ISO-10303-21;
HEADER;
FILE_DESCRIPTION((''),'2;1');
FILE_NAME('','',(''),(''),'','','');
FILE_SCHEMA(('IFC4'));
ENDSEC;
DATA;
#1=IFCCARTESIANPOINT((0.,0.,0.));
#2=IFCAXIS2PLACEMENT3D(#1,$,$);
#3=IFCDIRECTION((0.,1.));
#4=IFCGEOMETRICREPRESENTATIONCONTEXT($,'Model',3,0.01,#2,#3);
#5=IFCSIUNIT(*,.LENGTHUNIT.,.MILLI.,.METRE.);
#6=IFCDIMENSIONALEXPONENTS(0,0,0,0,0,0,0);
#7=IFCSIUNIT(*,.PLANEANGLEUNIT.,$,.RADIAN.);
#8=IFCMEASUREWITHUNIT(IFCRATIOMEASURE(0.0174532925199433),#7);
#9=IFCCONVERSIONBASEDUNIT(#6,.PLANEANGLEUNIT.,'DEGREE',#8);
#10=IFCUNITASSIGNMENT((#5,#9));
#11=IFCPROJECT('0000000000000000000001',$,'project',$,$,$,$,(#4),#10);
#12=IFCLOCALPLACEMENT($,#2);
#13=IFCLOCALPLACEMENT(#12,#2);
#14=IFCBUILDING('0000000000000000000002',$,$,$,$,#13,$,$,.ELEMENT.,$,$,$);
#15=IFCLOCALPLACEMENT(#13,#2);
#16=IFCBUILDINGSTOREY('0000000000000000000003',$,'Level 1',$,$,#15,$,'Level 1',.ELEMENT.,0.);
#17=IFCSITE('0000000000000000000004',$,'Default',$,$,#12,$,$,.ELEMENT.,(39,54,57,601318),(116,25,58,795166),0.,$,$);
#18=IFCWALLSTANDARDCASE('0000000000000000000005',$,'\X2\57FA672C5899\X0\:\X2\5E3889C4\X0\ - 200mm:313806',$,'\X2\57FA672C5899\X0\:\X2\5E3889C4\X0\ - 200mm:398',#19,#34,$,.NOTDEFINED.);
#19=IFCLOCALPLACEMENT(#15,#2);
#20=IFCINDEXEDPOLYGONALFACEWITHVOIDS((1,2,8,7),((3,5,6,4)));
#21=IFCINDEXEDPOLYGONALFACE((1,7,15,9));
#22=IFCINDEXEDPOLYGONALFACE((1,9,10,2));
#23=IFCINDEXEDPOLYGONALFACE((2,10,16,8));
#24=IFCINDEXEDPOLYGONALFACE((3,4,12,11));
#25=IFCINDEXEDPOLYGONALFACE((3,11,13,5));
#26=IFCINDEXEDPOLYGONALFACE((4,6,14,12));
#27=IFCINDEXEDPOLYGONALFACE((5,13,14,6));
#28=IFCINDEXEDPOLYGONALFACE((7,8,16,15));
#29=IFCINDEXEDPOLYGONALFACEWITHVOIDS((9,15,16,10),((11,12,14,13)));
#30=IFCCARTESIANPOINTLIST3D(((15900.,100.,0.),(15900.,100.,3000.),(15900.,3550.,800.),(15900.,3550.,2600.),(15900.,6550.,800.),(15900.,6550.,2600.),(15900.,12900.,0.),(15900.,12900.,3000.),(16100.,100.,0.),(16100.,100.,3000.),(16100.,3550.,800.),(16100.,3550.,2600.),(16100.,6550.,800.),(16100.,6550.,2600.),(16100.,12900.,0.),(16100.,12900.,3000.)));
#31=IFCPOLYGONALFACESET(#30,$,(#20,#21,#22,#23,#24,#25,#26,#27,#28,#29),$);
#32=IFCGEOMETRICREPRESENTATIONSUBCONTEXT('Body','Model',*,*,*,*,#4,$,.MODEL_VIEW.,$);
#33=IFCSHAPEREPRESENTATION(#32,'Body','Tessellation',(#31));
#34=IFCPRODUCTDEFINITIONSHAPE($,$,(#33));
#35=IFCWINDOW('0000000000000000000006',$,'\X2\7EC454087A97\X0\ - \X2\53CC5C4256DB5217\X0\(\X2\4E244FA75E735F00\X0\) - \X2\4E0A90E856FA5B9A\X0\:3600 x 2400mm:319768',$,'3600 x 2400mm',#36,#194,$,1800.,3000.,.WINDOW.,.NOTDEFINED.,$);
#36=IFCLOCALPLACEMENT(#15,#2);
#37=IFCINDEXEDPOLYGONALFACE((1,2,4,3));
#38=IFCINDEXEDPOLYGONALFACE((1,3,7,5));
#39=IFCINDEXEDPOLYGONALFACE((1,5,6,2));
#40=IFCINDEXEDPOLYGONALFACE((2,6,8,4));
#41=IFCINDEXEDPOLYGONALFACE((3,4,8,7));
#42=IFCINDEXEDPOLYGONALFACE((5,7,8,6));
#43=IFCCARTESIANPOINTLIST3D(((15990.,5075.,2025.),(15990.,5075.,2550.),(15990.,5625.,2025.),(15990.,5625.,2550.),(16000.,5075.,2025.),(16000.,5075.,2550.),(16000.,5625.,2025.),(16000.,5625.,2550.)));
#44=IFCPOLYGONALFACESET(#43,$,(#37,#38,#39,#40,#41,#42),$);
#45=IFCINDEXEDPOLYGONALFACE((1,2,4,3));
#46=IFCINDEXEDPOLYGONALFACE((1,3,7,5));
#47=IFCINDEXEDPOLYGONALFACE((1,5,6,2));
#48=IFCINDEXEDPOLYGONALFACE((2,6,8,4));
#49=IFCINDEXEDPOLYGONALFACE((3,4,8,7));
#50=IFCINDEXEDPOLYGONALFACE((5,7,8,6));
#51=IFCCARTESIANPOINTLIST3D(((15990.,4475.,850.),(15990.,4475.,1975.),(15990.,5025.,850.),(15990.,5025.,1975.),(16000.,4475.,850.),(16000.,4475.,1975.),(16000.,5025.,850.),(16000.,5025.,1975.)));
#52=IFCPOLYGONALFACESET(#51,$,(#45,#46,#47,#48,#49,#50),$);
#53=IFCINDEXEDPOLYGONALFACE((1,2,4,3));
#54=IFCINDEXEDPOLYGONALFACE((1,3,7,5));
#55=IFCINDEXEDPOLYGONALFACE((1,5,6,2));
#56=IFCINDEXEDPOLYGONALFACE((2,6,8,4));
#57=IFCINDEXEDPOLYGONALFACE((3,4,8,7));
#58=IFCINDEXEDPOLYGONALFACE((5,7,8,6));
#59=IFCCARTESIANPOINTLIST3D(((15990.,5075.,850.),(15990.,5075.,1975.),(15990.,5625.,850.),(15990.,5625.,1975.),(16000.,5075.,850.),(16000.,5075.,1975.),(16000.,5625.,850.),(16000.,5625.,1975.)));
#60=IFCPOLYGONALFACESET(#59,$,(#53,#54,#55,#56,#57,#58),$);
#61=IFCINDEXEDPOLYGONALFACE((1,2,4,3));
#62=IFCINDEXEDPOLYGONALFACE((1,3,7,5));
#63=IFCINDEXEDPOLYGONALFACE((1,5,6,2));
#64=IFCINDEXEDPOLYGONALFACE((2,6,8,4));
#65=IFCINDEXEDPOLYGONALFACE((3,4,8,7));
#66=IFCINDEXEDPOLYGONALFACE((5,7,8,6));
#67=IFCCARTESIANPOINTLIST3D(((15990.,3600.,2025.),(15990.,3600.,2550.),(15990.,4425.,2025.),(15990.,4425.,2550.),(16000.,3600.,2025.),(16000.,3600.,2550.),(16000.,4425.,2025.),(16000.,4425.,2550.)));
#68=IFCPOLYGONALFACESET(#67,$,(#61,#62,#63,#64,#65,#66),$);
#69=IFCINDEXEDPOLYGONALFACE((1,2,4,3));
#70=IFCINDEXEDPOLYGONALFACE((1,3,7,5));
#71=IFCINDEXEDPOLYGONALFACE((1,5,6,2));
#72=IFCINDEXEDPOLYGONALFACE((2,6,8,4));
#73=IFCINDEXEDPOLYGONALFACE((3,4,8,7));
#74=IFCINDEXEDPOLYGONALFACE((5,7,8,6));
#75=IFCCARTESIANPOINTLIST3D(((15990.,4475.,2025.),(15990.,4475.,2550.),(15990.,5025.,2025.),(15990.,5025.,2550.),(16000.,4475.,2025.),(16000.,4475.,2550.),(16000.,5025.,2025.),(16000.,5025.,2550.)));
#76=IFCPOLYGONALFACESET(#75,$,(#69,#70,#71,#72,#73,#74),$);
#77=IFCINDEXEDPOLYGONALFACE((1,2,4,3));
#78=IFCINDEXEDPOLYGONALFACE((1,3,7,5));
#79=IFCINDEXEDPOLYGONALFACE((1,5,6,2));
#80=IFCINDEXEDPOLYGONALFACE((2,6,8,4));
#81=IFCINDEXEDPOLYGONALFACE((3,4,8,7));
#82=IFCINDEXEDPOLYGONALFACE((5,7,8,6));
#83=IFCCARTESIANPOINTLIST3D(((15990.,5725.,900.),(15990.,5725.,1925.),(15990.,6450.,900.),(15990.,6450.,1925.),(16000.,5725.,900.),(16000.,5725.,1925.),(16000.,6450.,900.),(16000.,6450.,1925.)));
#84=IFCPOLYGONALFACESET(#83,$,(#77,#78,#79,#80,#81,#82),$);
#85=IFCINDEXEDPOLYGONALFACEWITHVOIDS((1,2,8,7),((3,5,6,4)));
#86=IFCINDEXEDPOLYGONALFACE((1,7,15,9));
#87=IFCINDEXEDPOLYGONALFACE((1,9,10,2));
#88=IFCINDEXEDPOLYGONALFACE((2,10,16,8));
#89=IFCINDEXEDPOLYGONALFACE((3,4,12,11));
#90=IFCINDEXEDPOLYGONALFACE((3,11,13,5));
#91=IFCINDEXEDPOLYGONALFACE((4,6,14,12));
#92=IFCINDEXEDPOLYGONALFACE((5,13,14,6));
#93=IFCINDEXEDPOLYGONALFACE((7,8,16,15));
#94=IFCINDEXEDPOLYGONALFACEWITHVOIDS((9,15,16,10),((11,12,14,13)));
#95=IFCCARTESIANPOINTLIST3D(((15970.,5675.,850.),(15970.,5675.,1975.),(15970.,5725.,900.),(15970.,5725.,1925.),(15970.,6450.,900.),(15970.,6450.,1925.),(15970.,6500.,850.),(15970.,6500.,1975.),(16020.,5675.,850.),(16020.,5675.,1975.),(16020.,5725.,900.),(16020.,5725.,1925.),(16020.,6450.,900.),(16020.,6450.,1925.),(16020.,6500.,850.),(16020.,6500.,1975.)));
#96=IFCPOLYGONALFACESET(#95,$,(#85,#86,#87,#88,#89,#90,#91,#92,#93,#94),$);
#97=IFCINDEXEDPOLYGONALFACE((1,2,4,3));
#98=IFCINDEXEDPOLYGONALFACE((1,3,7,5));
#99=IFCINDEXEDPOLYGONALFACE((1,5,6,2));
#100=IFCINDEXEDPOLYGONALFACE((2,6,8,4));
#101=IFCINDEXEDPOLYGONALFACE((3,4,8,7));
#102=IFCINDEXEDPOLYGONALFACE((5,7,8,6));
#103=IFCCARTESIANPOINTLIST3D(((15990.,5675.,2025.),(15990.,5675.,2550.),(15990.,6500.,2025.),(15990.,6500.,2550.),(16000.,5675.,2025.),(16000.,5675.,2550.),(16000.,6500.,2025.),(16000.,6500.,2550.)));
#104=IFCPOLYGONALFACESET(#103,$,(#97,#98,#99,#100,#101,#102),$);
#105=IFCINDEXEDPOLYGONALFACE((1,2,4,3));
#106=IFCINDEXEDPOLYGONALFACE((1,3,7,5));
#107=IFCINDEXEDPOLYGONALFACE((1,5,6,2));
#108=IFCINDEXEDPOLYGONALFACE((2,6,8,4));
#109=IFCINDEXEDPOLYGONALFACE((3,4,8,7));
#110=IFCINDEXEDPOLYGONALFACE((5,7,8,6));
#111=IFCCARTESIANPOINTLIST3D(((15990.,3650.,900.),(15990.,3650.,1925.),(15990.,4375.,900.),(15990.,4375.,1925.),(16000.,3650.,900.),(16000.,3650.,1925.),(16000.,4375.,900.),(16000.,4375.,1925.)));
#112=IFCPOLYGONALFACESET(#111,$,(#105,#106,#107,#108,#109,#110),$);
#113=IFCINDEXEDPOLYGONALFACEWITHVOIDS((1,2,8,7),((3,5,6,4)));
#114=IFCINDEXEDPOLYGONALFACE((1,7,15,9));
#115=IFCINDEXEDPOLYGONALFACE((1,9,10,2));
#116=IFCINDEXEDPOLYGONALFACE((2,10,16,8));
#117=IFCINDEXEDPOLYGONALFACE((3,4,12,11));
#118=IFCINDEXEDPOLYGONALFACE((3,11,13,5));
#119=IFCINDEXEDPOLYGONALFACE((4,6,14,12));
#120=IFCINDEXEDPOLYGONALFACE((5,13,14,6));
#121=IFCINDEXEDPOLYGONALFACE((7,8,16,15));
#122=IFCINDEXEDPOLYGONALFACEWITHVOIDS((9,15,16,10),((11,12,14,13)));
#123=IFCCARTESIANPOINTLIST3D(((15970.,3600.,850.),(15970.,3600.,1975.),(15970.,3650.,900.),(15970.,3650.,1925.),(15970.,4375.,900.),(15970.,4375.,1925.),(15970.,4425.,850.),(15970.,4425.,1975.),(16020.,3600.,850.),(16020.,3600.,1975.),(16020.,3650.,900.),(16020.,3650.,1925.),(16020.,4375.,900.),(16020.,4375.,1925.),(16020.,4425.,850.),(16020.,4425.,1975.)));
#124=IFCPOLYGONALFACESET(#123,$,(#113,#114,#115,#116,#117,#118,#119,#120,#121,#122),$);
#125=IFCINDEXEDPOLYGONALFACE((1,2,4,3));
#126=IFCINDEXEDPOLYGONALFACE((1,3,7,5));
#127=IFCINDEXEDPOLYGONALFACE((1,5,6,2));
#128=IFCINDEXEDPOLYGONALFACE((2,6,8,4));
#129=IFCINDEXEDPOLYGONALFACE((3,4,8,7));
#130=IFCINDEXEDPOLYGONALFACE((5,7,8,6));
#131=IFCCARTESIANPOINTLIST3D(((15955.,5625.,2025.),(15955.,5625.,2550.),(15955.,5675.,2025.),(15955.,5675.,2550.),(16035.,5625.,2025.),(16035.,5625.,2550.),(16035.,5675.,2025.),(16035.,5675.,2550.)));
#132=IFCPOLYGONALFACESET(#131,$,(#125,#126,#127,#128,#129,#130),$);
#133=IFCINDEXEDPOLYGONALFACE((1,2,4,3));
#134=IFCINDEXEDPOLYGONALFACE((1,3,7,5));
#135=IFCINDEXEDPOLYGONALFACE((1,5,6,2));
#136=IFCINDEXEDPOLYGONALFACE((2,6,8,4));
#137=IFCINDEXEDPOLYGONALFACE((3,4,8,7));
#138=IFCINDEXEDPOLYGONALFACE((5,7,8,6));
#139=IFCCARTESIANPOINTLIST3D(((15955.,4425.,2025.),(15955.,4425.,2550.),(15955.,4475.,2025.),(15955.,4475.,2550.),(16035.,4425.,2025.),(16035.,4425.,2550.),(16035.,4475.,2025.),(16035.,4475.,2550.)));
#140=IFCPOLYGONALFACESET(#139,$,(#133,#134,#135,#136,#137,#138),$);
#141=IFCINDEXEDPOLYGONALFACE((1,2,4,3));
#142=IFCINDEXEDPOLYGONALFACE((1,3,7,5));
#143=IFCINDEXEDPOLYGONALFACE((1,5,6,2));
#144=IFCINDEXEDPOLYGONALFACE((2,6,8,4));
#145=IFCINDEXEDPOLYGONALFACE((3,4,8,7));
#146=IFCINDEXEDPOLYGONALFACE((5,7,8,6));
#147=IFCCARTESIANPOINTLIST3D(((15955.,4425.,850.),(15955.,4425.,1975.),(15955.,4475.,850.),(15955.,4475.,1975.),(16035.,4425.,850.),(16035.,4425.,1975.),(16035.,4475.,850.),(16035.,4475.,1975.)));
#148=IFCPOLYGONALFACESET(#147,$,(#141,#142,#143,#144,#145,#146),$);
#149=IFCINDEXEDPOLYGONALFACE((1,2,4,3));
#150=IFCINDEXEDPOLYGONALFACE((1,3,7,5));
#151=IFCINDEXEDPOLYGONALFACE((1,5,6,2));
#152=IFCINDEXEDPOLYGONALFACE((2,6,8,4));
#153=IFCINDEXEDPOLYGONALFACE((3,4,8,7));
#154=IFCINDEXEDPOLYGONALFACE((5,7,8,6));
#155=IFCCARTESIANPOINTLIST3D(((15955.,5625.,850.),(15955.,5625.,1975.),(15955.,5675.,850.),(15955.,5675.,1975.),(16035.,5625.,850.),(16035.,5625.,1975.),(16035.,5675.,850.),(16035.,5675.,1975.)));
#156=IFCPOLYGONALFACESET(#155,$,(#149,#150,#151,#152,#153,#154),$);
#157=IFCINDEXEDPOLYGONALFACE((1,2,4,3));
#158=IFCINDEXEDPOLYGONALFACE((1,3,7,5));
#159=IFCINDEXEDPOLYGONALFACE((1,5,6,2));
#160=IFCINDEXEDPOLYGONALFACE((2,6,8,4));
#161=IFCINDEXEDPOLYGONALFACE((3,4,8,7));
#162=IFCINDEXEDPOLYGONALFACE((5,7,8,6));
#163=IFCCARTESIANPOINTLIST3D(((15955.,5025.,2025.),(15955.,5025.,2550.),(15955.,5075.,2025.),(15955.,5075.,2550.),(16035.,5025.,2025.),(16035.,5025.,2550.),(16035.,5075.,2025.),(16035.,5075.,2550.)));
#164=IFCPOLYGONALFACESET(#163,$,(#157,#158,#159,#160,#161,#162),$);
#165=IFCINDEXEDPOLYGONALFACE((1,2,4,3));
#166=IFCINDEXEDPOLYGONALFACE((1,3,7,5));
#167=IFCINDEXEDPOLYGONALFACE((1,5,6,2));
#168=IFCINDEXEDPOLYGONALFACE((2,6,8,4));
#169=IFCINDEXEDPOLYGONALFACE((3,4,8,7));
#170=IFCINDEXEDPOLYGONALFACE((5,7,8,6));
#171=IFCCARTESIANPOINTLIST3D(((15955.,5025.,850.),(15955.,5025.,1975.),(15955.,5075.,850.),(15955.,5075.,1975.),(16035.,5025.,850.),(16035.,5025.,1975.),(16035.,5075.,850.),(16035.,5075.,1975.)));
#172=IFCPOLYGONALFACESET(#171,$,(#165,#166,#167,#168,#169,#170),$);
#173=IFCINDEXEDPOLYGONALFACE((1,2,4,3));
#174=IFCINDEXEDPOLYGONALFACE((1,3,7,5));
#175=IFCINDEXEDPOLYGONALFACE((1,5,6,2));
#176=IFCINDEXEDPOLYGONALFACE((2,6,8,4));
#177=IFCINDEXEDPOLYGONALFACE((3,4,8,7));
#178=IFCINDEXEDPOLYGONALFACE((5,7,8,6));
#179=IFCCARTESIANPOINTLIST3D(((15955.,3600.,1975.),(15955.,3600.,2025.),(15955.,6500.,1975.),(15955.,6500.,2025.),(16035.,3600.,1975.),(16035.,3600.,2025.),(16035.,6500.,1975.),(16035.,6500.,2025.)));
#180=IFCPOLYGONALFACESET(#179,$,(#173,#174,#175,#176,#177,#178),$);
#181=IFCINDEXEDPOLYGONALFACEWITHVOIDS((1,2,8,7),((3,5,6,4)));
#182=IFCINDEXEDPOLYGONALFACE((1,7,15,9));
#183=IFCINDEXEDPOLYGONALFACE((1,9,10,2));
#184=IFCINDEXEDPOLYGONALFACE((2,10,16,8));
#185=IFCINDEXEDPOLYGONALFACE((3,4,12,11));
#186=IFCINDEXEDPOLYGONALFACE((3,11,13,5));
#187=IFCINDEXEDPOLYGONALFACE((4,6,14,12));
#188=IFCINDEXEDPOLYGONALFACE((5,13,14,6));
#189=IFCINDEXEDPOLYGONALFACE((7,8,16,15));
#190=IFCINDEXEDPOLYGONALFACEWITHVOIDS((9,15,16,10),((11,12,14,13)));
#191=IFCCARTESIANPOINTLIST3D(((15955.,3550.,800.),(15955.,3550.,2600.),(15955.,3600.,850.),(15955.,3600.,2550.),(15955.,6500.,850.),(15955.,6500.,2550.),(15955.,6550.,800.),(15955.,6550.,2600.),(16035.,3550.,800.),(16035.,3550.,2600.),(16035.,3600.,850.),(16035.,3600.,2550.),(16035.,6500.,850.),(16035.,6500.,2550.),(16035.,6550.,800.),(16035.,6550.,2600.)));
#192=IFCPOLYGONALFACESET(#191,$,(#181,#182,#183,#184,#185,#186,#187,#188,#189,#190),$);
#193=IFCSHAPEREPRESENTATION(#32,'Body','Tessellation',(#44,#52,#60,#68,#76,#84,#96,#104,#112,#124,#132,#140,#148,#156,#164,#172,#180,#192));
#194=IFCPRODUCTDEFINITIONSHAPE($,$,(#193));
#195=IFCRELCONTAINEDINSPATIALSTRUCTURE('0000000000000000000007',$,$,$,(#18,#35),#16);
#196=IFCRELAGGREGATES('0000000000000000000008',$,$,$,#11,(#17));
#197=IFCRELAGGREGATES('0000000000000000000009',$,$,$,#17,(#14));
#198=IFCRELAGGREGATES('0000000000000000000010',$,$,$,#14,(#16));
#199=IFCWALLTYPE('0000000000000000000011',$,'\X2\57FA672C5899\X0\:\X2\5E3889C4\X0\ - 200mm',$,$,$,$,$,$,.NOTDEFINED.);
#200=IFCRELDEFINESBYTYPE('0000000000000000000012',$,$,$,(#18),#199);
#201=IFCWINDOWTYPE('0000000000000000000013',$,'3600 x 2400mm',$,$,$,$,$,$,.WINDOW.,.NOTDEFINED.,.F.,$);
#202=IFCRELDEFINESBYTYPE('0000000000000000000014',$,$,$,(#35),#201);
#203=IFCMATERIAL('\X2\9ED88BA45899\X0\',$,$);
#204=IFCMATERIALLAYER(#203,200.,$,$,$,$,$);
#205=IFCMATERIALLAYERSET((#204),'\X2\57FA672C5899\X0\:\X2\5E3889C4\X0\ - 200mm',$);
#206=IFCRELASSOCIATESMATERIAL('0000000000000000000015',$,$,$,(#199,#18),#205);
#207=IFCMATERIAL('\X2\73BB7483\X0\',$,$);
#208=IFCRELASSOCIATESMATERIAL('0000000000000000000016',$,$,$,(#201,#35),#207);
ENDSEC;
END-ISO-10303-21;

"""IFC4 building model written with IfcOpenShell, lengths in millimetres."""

from ifc_helpers import new_model, entity, si_unit, converted_unit, direction, frame, frame_2d, origin, origin_2d_with_axis, place, context, subcontext, project, spatial, polyline, rectangle, outline, extrude, source, transform, mapped, material, layer, layer_set, layer_usage, type_object, type_shapes, element, fill, save


model = new_model("IFC4")

# Units and contexts
model_context = context("Model", 3, precision=0.01, world=origin(), true_north=direction((0.0, 1.0)))
body_context = subcontext(model_context, "Body", "Model", "MODEL_VIEW")
ifc_project = project(units=[si_unit("LENGTHUNIT", "METRE", prefix="MILLI"), converted_unit("PLANEANGLEUNIT", "DEGREE", entity("IfcRatioMeasure", 0.0174532925199433), si_unit("PLANEANGLEUNIT", "RADIAN"), dimensions=[0, 0, 0, 0, 0, 0, 0])], contexts=[model_context])

# Site, building, storey
site_placement = place(None, origin())
site = spatial("IfcSite", under=ifc_project, at=site_placement, Name="Default", CompositionType="ELEMENT", RefLatitude=(39, 54, 57, 601318), RefLongitude=(116, 25, 58, 795166), RefElevation=0.0)
building_placement = place(site_placement, origin())
building = spatial("IfcBuilding", under=site, at=building_placement, CompositionType="ELEMENT")
storey_placement = place(building_placement, origin())
storey = spatial("IfcBuildingStorey", under=building, at=storey_placement, Name="Level 1", LongName="Level 1", CompositionType="ELEMENT", Elevation=0.0)

# Shared definitions
ifc_material_1 = material(Name="默认墙")
ifc_layer = layer(ifc_material_1, 200.0)
ifc_layer_set = layer_set([ifc_layer], Name="基本墙:常规 - 200mm")
wall_type = type_object("IfcWallType", Name="基本墙:常规 - 200mm", PredefinedType="NOTDEFINED", material=ifc_layer_set)
ifc_material_2 = material(Name="玻璃")
window_type_1 = type_object("IfcWindowType", Name="3600 x 2400mm", ParameterTakesPrecedence=False, PartitioningType="NOTDEFINED", PredefinedType="WINDOW", material=ifc_material_2)
shared_shape_1 = source(origin(), body_context, "Body", "SweptSolid", [
    extrude(rectangle(XDim=10.0, YDim=550.0, at=origin_2d_with_axis()), frame((1200.0, 95.0, 1225.0), z_axis=(0.0, 0.0, 1.0), x_axis=(0.0, 1.0, 0.0)), (0.0, 0.0, 1.0), 525.0),
    extrude(rectangle(XDim=10.0, YDim=550.0, at=origin_2d_with_axis()), frame((1800.0, 95.0, 50.0), z_axis=(0.0, 0.0, 1.0), x_axis=(0.0, 1.0, 0.0)), (0.0, 0.0, 1.0), 1125.0),
    extrude(rectangle(XDim=10.0, YDim=550.0, at=origin_2d_with_axis()), frame((1200.0, 95.0, 50.0), z_axis=(0.0, 0.0, 1.0), x_axis=(0.0, 1.0, 0.0)), (0.0, 0.0, 1.0), 1125.0),
    extrude(rectangle(XDim=10.0, YDim=825.0, at=frame_2d((0.0, 0.0), x_axis=(1.0, 0.0))), frame((2537.5, 95.0, 1225.0), z_axis=(0.0, 0.0, 1.0), x_axis=(0.0, 1.0, 0.0)), (0.0, 0.0, 1.0), 525.0),
    extrude(rectangle(XDim=10.0, YDim=550.0, at=frame_2d((0.0, 0.0), x_axis=(1.0, 0.0))), frame((1800.0, 95.0, 1225.0), z_axis=(0.0, 0.0, 1.0), x_axis=(0.0, 1.0, 0.0)), (0.0, 0.0, 1.0), 525.0),
    extrude(rectangle(XDim=10.0, YDim=725.0, at=frame_2d((0.0, 0.0), x_axis=(1.0, 0.0))), frame((462.5, 95.0, 100.0), z_axis=(0.0, 0.0, 1.0), x_axis=(0.0, 1.0, 0.0)), (0.0, 0.0, 1.0), 1025.0),
    extrude(outline(polyline([(-562.5, -412.5), (562.5, -412.5), (562.5, 412.5), (-562.5, 412.5), (-562.5, -412.5)]), holes=[polyline([(512.5, -362.5), (-512.5, -362.5), (-512.5, 362.5), (512.5, 362.5), (512.5, -362.5)])]), frame((462.5, 70.0, 612.5), z_axis=(0.0, 1.0, 0.0), x_axis=(0.0, 0.0, -1.0)), (0.0, 0.0, 1.0), 50.0),
    extrude(rectangle(XDim=10.0, YDim=825.0, at=origin_2d_with_axis()), frame((462.5, 95.0, 1225.0), z_axis=(0.0, 0.0, 1.0), x_axis=(0.0, 1.0, 0.0)), (0.0, 0.0, 1.0), 525.0),
    extrude(rectangle(XDim=10.0, YDim=725.0, at=frame_2d((0.0, 0.0), x_axis=(1.0, 0.0))), frame((2537.5, 95.0, 100.0), z_axis=(0.0, 0.0, 1.0), x_axis=(0.0, 1.0, 0.0)), (0.0, 0.0, 1.0), 1025.0),
    extrude(outline(polyline([(-562.5, -412.5), (562.5, -412.5), (562.5, 412.5), (-562.5, 412.5), (-562.5, -412.5)]), holes=[polyline([(512.5, -362.5), (-512.5, -362.5), (-512.5, 362.5), (512.5, 362.5), (512.5, -362.5)])]), frame((2537.5, 70.0, 612.5), z_axis=(0.0, 1.0, 0.0), x_axis=(0.0, 0.0, -1.0)), (0.0, 0.0, 1.0), 50.0),
    extrude(rectangle(XDim=80.0, YDim=50.0, at=origin_2d_with_axis()), frame((900.0, 95.0, 1225.0), z_axis=(0.0, 0.0, 1.0), x_axis=(0.0, -1.0, 0.0)), (0.0, 0.0, 1.0), 525.0),
    extrude(rectangle(XDim=80.0, YDim=50.0, at=frame_2d((0.0, 0.0), x_axis=(1.0, 0.0))), frame((2100.0, 95.0, 1225.0), z_axis=(0.0, 0.0, 1.0), x_axis=(0.0, -1.0, 0.0)), (0.0, 0.0, 1.0), 525.0),
    extrude(rectangle(XDim=80.0, YDim=50.0, at=origin_2d_with_axis()), frame((2100.0, 95.0, 50.0), z_axis=(0.0, 0.0, 1.0), x_axis=(0.0, -1.0, 0.0)), (0.0, 0.0, 1.0), 1125.0),
    extrude(rectangle(XDim=80.0, YDim=50.0, at=origin_2d_with_axis()), frame((900.0, 95.0, 50.0), z_axis=(0.0, 0.0, 1.0), x_axis=(0.0, -1.0, 0.0)), (0.0, 0.0, 1.0), 1125.0),
    extrude(rectangle(XDim=80.0, YDim=50.0, at=frame_2d((0.0, 0.0), x_axis=(1.0, 0.0))), frame((1500.0, 95.0, 1225.0), z_axis=(0.0, 0.0, 1.0), x_axis=(0.0, -1.0, 0.0)), (0.0, 0.0, 1.0), 525.0),
    extrude(rectangle(XDim=80.0, YDim=50.0, at=origin_2d_with_axis()), frame((1500.0, 95.0, 50.0), z_axis=(0.0, 0.0, 1.0), x_axis=(0.0, -1.0, 0.0)), (0.0, 0.0, 1.0), 1125.0),
    extrude(rectangle(XDim=80.0, YDim=2900.0, at=frame_2d((0.0, 0.0), x_axis=(1.0, 0.0))), frame((1500.0, 95.0, 1175.0), z_axis=(0.0, 0.0, 1.0), x_axis=(0.0, -1.0, 0.0)), (0.0, 0.0, 1.0), 50.0),
    extrude(outline(polyline([(-1500.0, -900.0), (1500.0, -900.0), (1500.0, 900.0), (-1500.0, 900.0), (-1500.0, -900.0)]), holes=[polyline([(1450.0, -850.0), (-1450.0, -850.0), (-1450.0, 850.0), (1450.0, 850.0), (1450.0, -850.0)])]), frame((1500.0, 55.0, 900.0), z_axis=(0.0, 1.0, 0.0), x_axis=(1.0, 0.0, 0.0)), (0.0, 0.0, 1.0), 80.0),
])
type_shapes(window_type_1, [shared_shape_1])

# Wall, opening, window
ifc_layer_usage_1 = layer_usage(ifc_layer_set, "AXIS2", "NEGATIVE", 100.0)
wall_1_placement = place(storey_placement, frame((16000.0, 12900.0, 0.0), z_axis=(0.0, 0.0, 1.0), x_axis=(0.0, -1.0, 0.0)))
wall_1 = element("IfcWallStandardCase", 1, at=wall_1_placement, inside=storey, type_object=wall_type, material=ifc_layer_usage_1, Name="基本墙:常规 - 200mm:313806", ObjectType="基本墙:常规 - 200mm:398", PredefinedType="NOTDEFINED", context=body_context, shape_type="SweptSolid", body=[
    extrude(rectangle(XDim=12800.0, YDim=200.0, at=frame_2d((6400.0, 0.0), x_axis=(-1.0, 0.0))), origin(), (0.0, 0.0, 1.0), 3000.0),
])
opening_1_placement = place(wall_1_placement, frame((6350.0, -100.0, 800.0)))
opening_1 = element("IfcOpeningElement", 2, at=opening_1_placement, cuts=wall_1, ObjectType="Opening", PredefinedType="OPENING", context=body_context, shape_type="SweptSolid", body=[
    extrude(rectangle(XDim=1800.0, YDim=3000.0, at=frame_2d((900.0, 1500.0), x_axis=(1.0, 0.0))), frame((0.0, 0.0, 0.0), z_axis=(0.0, 1.0, 0.0), x_axis=(0.0, 0.0, 1.0)), (0.0, 0.0, 1.0), 200.0),
])
window_1_placement = place(opening_1_placement, origin())
window_1 = element("IfcWindow", 3, at=window_1_placement, inside=storey, type_object=window_type_1, material=ifc_material_2, Name="组合窗 - 双层四列(两侧平开) - 上部固定:3600 x 2400mm:319768", ObjectType="3600 x 2400mm", OverallHeight=1800.0, OverallWidth=3000.0, PartitioningType="NOTDEFINED", PredefinedType="WINDOW", context=body_context, shape_type="MappedRepresentation", body=[
    mapped(shared_shape_1, transform((0.0, 0.0, 0.0), scale=1.0)),
])
fill(opening_1, window_1)

save(model, "model.ifc")
